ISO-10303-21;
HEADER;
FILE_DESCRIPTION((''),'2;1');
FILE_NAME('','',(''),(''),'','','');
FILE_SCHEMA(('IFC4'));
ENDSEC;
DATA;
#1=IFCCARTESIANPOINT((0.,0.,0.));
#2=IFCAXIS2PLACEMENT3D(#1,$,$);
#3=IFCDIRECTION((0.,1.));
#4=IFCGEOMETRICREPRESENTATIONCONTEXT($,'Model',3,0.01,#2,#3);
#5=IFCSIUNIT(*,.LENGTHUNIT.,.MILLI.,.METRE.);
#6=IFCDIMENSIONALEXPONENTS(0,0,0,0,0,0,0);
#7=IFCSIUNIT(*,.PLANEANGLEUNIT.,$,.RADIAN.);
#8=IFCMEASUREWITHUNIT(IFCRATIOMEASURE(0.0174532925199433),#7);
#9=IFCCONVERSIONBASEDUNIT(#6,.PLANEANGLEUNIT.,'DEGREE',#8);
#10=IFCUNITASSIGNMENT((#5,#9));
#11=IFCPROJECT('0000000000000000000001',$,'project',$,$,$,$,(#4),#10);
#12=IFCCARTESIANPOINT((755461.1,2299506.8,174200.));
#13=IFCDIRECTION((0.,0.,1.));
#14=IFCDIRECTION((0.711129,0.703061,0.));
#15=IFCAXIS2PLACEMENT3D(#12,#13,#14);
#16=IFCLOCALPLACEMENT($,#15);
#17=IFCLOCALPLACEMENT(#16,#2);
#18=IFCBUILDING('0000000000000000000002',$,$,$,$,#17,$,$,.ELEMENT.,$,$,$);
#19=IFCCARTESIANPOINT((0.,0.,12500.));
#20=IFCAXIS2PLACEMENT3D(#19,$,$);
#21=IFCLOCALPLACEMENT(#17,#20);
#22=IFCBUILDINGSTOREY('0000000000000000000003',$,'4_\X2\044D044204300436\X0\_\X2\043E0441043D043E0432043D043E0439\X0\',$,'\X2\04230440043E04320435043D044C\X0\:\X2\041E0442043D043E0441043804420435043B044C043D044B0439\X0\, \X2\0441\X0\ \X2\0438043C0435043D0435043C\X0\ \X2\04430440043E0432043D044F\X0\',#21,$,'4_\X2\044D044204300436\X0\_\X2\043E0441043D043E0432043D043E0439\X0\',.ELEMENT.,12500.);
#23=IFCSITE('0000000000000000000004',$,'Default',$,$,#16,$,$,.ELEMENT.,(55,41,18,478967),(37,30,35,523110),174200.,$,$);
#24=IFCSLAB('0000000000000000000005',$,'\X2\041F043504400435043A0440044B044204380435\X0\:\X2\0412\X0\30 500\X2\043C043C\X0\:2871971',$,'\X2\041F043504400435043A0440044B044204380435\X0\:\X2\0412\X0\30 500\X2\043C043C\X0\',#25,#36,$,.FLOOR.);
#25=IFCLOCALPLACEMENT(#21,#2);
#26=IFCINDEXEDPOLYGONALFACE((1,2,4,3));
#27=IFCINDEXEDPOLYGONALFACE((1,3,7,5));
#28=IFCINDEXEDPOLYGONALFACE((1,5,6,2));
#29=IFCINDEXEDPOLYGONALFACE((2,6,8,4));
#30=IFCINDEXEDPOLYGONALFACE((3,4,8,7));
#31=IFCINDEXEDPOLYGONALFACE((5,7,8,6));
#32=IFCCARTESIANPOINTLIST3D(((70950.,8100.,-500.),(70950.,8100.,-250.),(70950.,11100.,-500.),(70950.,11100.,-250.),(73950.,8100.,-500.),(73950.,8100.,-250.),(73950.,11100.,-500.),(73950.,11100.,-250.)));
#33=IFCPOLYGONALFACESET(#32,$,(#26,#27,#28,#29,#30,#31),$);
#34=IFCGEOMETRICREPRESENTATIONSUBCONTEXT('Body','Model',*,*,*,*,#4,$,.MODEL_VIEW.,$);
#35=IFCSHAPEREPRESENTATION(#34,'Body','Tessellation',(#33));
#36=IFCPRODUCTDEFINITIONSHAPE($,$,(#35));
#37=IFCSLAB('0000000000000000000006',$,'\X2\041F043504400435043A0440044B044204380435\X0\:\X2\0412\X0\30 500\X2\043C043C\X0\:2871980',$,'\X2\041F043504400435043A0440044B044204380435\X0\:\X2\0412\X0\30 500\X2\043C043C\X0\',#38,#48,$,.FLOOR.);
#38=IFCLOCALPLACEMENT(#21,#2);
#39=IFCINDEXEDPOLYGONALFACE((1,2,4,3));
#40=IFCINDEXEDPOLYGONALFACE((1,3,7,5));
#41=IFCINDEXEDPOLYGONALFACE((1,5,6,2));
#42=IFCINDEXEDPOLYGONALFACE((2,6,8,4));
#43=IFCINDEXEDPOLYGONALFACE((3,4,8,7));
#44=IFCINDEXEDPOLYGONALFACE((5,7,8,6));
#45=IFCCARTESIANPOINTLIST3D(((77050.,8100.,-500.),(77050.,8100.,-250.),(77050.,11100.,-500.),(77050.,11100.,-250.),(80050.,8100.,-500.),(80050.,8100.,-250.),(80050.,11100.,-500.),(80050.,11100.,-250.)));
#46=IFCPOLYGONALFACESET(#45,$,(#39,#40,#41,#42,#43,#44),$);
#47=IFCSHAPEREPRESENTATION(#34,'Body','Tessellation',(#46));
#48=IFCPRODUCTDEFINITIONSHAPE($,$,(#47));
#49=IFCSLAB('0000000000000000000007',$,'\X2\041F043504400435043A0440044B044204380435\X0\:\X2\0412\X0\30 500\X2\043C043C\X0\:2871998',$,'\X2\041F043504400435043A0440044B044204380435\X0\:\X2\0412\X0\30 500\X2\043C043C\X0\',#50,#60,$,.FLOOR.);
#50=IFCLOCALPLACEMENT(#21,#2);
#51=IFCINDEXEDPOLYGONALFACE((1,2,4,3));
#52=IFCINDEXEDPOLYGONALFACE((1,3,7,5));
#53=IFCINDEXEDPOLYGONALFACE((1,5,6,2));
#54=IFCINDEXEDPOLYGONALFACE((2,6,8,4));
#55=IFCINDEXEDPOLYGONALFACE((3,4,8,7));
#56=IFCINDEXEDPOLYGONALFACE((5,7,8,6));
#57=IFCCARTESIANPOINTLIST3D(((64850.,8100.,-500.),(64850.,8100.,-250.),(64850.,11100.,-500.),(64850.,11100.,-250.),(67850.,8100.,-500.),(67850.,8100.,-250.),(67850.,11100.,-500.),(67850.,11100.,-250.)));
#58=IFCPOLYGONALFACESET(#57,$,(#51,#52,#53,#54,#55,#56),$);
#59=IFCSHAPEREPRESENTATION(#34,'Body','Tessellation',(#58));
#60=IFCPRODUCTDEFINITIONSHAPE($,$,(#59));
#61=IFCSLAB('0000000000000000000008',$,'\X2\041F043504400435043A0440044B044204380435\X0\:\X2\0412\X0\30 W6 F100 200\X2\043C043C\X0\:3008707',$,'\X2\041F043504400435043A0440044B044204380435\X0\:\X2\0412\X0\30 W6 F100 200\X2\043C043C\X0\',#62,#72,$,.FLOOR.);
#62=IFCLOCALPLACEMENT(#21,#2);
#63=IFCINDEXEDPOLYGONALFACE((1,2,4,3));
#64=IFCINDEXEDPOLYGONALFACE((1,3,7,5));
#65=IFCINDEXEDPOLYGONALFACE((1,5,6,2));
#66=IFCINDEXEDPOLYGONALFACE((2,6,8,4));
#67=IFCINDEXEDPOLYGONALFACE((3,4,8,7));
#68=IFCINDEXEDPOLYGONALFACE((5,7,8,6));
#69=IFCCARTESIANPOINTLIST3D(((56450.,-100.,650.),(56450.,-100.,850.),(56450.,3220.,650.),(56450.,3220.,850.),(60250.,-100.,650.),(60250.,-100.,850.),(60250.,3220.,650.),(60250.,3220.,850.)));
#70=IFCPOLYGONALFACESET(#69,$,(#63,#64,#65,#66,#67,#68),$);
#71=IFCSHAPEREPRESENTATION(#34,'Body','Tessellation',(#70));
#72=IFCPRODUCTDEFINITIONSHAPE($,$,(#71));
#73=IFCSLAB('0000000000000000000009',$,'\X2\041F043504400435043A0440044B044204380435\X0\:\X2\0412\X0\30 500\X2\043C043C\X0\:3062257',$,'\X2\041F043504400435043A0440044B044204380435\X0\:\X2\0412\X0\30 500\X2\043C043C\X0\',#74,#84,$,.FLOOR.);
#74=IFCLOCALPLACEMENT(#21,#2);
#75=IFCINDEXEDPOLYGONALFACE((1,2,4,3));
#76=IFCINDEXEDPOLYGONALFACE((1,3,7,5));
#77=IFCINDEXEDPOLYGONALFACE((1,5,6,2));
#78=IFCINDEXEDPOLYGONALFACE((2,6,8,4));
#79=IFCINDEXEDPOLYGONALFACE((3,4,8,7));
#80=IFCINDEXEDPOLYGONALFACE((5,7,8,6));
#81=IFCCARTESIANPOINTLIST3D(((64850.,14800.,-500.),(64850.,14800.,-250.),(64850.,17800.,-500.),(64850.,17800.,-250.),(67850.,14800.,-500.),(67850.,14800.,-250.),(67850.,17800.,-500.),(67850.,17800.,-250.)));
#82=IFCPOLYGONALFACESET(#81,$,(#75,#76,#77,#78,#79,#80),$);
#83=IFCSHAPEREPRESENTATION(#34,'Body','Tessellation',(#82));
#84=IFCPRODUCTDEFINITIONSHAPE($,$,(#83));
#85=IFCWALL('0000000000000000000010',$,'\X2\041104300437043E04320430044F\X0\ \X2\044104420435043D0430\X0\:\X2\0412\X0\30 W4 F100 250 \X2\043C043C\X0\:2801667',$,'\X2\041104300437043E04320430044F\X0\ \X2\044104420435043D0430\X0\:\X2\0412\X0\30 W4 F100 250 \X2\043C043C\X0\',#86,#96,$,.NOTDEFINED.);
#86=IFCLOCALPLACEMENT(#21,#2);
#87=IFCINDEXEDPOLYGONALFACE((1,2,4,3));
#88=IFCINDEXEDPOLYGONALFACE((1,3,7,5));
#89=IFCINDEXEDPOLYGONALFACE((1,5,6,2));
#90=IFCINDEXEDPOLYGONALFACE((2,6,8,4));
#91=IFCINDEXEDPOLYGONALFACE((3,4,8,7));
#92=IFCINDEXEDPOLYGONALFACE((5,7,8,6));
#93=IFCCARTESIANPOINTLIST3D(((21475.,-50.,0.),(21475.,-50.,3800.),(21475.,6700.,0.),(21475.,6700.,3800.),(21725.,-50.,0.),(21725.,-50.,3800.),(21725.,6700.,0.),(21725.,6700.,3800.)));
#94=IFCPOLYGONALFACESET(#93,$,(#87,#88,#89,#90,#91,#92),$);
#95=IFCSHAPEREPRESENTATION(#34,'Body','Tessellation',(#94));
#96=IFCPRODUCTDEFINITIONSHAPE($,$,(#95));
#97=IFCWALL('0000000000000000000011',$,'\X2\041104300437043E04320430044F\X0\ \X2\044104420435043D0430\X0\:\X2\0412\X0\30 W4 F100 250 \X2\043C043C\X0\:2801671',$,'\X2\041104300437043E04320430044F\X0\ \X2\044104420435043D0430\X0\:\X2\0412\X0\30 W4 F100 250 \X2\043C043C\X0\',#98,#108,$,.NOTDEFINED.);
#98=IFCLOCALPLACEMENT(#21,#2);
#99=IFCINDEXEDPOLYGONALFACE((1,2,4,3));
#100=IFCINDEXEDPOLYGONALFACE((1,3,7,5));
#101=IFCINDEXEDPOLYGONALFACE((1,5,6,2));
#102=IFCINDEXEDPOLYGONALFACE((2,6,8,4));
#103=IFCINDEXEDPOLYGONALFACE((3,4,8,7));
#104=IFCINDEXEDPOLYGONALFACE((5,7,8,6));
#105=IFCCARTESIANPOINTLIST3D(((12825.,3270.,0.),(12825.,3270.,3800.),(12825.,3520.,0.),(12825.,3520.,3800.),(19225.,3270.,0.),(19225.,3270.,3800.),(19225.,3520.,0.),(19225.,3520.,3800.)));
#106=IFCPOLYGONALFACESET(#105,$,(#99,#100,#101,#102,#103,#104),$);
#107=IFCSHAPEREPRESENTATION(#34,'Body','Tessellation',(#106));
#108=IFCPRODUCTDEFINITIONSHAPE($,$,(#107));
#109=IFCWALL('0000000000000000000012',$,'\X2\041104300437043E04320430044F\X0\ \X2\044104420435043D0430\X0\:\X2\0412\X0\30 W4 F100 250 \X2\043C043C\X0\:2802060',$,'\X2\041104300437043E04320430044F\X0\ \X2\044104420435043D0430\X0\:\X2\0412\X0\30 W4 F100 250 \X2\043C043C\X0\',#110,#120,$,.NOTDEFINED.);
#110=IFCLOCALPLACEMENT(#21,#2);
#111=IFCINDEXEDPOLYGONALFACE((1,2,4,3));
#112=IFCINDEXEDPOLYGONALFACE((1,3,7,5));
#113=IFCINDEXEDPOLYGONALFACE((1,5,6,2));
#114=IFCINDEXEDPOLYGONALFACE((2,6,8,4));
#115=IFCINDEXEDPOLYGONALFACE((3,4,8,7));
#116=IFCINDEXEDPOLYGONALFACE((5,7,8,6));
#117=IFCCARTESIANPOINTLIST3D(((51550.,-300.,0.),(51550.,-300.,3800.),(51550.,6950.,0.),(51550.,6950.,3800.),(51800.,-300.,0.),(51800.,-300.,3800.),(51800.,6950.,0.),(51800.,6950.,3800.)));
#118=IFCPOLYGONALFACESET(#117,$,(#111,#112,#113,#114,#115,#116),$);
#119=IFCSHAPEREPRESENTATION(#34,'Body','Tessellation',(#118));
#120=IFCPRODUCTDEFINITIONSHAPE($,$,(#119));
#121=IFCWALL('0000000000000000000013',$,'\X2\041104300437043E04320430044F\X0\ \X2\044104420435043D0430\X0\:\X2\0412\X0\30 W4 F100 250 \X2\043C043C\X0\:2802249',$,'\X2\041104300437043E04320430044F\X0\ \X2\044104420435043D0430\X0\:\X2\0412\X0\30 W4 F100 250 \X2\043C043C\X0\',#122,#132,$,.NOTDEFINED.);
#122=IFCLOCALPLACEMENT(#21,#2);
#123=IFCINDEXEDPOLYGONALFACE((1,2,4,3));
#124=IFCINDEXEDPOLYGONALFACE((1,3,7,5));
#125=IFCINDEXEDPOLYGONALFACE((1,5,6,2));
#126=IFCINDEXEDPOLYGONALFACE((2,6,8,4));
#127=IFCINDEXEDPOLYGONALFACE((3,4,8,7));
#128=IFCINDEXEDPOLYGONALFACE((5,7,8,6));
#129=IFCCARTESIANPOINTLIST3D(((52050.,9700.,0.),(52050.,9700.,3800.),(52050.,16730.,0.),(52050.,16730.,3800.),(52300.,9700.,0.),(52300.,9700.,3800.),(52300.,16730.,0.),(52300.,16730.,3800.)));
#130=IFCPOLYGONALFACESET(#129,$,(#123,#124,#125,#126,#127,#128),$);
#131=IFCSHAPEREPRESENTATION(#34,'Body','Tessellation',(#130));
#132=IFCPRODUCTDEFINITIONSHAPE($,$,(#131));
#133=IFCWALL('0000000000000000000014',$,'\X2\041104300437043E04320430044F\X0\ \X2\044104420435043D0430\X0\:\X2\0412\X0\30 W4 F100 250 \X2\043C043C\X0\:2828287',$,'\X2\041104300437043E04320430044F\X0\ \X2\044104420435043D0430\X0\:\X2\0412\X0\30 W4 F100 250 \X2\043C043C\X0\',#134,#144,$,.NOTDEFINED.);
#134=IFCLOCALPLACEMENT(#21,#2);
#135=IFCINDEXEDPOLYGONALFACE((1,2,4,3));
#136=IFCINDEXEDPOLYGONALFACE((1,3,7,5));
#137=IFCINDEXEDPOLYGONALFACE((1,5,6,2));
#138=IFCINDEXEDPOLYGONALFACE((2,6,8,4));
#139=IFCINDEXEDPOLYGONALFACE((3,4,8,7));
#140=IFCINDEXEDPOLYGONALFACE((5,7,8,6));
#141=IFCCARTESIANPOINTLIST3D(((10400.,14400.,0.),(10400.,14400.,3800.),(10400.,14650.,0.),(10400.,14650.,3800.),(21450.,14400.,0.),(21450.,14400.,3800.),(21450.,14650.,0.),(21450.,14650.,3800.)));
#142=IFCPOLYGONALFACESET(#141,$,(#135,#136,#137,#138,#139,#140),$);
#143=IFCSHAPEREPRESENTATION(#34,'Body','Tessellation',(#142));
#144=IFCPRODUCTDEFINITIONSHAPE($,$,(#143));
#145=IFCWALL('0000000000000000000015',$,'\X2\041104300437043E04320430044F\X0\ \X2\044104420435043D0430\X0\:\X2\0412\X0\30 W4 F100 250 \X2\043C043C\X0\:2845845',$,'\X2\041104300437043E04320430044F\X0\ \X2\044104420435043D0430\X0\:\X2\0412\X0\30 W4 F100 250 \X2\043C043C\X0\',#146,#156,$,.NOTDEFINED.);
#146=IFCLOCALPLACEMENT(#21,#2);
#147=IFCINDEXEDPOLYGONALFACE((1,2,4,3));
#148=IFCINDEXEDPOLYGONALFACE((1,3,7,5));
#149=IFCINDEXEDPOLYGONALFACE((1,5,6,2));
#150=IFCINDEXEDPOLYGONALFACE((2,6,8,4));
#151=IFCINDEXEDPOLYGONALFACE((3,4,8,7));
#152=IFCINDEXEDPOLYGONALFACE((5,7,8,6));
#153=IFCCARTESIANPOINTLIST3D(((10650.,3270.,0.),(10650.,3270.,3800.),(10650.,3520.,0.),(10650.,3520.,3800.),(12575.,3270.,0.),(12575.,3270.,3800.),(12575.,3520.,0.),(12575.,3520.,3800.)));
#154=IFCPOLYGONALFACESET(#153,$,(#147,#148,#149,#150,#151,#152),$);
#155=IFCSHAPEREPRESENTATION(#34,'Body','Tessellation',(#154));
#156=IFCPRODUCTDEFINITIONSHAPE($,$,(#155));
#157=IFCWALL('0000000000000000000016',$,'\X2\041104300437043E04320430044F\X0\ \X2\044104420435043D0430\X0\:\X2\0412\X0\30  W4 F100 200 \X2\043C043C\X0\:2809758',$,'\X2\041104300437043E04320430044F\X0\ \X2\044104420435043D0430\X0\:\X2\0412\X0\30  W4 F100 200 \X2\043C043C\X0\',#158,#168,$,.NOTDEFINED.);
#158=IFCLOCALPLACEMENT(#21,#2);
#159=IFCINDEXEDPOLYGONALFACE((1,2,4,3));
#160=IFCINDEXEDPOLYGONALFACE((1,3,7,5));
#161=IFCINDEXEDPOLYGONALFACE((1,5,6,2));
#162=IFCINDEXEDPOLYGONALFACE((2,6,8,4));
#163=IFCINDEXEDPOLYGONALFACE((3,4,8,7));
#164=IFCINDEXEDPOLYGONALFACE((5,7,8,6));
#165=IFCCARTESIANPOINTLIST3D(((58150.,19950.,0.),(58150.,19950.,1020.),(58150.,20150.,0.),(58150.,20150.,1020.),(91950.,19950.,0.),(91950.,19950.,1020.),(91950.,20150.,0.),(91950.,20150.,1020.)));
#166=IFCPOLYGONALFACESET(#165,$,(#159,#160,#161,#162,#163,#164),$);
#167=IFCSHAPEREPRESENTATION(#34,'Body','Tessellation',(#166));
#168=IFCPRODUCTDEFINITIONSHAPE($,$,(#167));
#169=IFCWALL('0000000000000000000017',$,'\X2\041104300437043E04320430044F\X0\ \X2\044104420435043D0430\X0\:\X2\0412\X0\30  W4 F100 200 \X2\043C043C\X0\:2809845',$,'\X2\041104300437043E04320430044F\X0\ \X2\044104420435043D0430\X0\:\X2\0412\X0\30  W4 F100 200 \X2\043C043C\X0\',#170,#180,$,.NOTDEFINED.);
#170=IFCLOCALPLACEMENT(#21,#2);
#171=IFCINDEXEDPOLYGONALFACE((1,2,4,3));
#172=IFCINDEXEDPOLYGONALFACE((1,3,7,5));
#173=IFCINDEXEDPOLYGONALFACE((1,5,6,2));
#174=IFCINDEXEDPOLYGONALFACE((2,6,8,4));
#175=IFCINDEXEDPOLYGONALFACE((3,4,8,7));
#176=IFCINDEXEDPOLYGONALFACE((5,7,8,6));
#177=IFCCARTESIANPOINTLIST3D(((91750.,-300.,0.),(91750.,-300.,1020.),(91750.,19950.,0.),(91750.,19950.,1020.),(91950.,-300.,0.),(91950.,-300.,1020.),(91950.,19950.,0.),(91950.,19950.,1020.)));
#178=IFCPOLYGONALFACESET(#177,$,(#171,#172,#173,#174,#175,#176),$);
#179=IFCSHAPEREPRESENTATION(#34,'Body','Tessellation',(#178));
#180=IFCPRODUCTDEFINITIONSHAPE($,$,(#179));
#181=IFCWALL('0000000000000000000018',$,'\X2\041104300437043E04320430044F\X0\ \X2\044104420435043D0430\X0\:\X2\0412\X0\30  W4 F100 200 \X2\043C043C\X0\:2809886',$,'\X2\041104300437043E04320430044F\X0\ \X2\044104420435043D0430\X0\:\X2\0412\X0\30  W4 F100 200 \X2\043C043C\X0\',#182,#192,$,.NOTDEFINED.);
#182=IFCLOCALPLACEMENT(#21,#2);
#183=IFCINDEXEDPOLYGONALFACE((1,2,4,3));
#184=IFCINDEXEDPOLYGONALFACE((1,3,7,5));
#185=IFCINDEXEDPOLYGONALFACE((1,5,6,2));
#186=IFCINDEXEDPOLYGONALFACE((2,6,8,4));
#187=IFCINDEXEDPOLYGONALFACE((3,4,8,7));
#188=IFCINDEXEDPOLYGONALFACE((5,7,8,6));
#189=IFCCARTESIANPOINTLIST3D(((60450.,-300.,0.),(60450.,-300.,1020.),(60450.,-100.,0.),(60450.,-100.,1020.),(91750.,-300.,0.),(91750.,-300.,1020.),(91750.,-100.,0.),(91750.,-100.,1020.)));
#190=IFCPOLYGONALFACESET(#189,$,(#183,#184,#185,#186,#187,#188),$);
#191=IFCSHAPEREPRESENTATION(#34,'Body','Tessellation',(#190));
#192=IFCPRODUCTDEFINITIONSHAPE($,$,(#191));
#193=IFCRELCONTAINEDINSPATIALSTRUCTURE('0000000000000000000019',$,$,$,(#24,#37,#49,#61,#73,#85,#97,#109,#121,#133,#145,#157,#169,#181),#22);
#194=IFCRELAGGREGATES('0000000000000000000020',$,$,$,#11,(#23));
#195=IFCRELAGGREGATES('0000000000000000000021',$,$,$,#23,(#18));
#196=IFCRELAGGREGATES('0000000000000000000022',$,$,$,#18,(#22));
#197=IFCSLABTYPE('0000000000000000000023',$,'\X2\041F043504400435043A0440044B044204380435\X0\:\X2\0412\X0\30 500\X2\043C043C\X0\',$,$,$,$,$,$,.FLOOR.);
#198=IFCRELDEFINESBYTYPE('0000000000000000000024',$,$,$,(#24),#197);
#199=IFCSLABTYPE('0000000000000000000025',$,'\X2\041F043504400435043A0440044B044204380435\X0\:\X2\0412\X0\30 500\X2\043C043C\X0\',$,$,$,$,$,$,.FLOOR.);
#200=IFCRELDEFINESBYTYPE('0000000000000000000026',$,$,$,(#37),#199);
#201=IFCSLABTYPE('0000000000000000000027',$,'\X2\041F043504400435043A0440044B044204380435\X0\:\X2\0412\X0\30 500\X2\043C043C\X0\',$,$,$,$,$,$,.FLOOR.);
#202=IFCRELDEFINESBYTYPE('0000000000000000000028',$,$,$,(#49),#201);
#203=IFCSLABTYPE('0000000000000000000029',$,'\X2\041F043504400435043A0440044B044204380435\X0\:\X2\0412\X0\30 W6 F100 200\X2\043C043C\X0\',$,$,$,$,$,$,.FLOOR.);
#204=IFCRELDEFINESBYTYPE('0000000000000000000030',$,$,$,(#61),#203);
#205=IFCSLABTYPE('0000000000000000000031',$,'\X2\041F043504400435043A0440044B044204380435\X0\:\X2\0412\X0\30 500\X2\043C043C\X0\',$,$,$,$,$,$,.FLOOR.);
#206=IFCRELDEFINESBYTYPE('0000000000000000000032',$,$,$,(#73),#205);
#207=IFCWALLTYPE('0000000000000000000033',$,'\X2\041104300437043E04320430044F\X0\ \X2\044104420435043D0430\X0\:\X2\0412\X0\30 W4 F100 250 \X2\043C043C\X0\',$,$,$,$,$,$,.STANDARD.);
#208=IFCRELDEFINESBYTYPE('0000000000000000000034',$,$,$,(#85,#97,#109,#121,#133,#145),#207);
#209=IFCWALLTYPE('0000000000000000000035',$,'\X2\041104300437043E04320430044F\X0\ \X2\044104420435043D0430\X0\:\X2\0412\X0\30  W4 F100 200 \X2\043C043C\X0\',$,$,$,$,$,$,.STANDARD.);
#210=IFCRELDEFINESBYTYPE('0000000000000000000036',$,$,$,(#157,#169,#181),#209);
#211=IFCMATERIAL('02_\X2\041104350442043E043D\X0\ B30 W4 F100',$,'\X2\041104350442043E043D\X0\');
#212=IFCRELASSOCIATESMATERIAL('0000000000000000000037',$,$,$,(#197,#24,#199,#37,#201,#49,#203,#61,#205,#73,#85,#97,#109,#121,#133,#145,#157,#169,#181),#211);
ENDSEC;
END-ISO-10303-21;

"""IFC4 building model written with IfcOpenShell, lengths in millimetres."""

from ifc_helpers import new_model, entity, si_unit, converted_unit, direction, frame, origin, place, context, subcontext, project, spatial, indexed_curve, outline, extrude, material, type_object, element, save


model = new_model("IFC4")

# Units and contexts
model_context = context("Model", 3, precision=0.01, world=origin(), true_north=direction((0.0, 1.0)))
body_context = subcontext(model_context, "Body", "Model", "MODEL_VIEW")
ifc_project = project(units=[si_unit("LENGTHUNIT", "METRE", prefix="MILLI"), converted_unit("PLANEANGLEUNIT", "DEGREE", entity("IfcRatioMeasure", 0.0174532925199433), si_unit("PLANEANGLEUNIT", "RADIAN"), dimensions=[0, 0, 0, 0, 0, 0, 0])], contexts=[model_context])

# Site, building, storey
site_placement = place(None, frame((755461.1, 2299506.8, 174200.0), z_axis=(0.0, 0.0, 1.0), x_axis=(0.711129, 0.703061, 0.0)))
site = spatial("IfcSite", under=ifc_project, at=site_placement, Name="Default", CompositionType="ELEMENT", RefLatitude=(55, 41, 18, 478967), RefLongitude=(37, 30, 35, 523110), RefElevation=174200.0)
building_placement = place(site_placement, origin())
building = spatial("IfcBuilding", under=site, at=building_placement, CompositionType="ELEMENT")
storey_placement = place(building_placement, frame((0.0, 0.0, 12500.0)))
storey = spatial("IfcBuildingStorey", under=building, at=storey_placement, Name="4_этаж_основной", ObjectType="Уровень:Относительный, с именем уровня", LongName="4_этаж_основной", CompositionType="ELEMENT", Elevation=12500.0)

# Slabs
ifc_material_1 = material(Name="02_Бетон B30 W4 F100", Category="Бетон")
slab_type_1 = type_object("IfcSlabType", Name="Перекрытие:В30 500мм", PredefinedType="FLOOR", material=ifc_material_1)
slab_1_placement = place(storey_placement, origin())
element("IfcSlab", 1, at=slab_1_placement, inside=storey, type_object=slab_type_1, material=ifc_material_1, Name="Перекрытие:В30 500мм:2871971", ObjectType="Перекрытие:В30 500мм", PredefinedType="FLOOR", context=body_context, shape_type="SweptSolid", body=[
    extrude(outline(indexed_curve([(-1500.0, -1500.0), (1500.0, -1500.0), (1500.0, 1500.0), (-1500.0, 1500.0), (-1500.0, -1500.0)], self_intersect=False)), frame((72450.0, 9600.0, -500.0), z_axis=(0.0, 0.0, 1.0), x_axis=(0.0, -1.0, 0.0)), (0.0, 0.0, 1.0), 250.0),
])
slab_type_2 = type_object("IfcSlabType", Name="Перекрытие:В30 500мм", PredefinedType="FLOOR", material=ifc_material_1)
slab_2_placement = place(storey_placement, origin())
element("IfcSlab", 2, at=slab_2_placement, inside=storey, type_object=slab_type_2, material=ifc_material_1, Name="Перекрытие:В30 500мм:2871980", ObjectType="Перекрытие:В30 500мм", PredefinedType="FLOOR", context=body_context, shape_type="SweptSolid", body=[
    extrude(outline(indexed_curve([(-1500.0, -1500.0), (1500.0, -1500.0), (1500.0, 1500.0), (-1500.0, 1500.0), (-1500.0, -1500.0)], self_intersect=False)), frame((78550.0, 9600.0, -500.0), z_axis=(0.0, 0.0, 1.0), x_axis=(0.0, -1.0, 0.0)), (0.0, 0.0, 1.0), 250.0),
])
slab_type_3 = type_object("IfcSlabType", Name="Перекрытие:В30 500мм", PredefinedType="FLOOR", material=ifc_material_1)
slab_3_placement = place(storey_placement, origin())
element("IfcSlab", 3, at=slab_3_placement, inside=storey, type_object=slab_type_3, material=ifc_material_1, Name="Перекрытие:В30 500мм:2871998", ObjectType="Перекрытие:В30 500мм", PredefinedType="FLOOR", context=body_context, shape_type="SweptSolid", body=[
    extrude(outline(indexed_curve([(-1500.0, -1500.0), (1500.0, -1500.0), (1500.0, 1500.0), (-1500.0, 1500.0), (-1500.0, -1500.0)], self_intersect=False)), frame((66350.0, 9600.0, -500.0), z_axis=(0.0, 0.0, 1.0), x_axis=(0.0, -1.0, 0.0)), (0.0, 0.0, 1.0), 250.0),
])
slab_type_4 = type_object("IfcSlabType", Name="Перекрытие:В30 W6 F100 200мм", PredefinedType="FLOOR", material=ifc_material_1)
slab_4_placement = place(storey_placement, origin())
element("IfcSlab", 4, at=slab_4_placement, inside=storey, type_object=slab_type_4, material=ifc_material_1, Name="Перекрытие:В30 W6 F100 200мм:3008707", ObjectType="Перекрытие:В30 W6 F100 200мм", PredefinedType="FLOOR", context=body_context, shape_type="SweptSolid", body=[
    extrude(outline(indexed_curve([(-1660.0, -1900.0), (1660.0, -1900.0), (1660.0, 1900.0), (-1660.0, 1900.0), (-1660.0, -1900.0)], self_intersect=False)), frame((58350.0, 1560.0, 850.0), z_axis=(0.0, 0.0, -1.0), x_axis=(0.0, 1.0, 0.0)), (0.0, 0.0, 1.0), 200.0),
])
slab_type_5 = type_object("IfcSlabType", Name="Перекрытие:В30 500мм", PredefinedType="FLOOR", material=ifc_material_1)
slab_5_placement = place(storey_placement, origin())
element("IfcSlab", 5, at=slab_5_placement, inside=storey, type_object=slab_type_5, material=ifc_material_1, Name="Перекрытие:В30 500мм:3062257", ObjectType="Перекрытие:В30 500мм", PredefinedType="FLOOR", context=body_context, shape_type="SweptSolid", body=[
    extrude(outline(indexed_curve([(-1500.0, -1500.0), (1500.0, -1500.0), (1500.0, 1500.0), (-1500.0, 1500.0), (-1500.0, -1500.0)], self_intersect=False)), frame((66350.0, 16300.0, -500.0), z_axis=(0.0, 0.0, 1.0), x_axis=(0.0, -1.0, 0.0)), (0.0, 0.0, 1.0), 250.0),
])

# Walls
wall_type_1 = type_object("IfcWallType", Name="Базовая стена:В30 W4 F100 250 мм", PredefinedType="STANDARD")
wall_1_placement = place(storey_placement, frame((21600.0, -50.0, 0.0), z_axis=(0.0, 0.0, 1.0), x_axis=(0.0, 1.0, 0.0)))
element("IfcWall", 6, at=wall_1_placement, inside=storey, type_object=wall_type_1, material=ifc_material_1, Name="Базовая стена:В30 W4 F100 250 мм:2801667", ObjectType="Базовая стена:В30 W4 F100 250 мм", PredefinedType="NOTDEFINED", context=body_context, shape_type="SweptSolid", body=[
    extrude(outline(indexed_curve([(6750.0, 125.0), (0.0, 125.0), (0.0, -125.0), (6750.0, -125.0), (6750.0, 125.0)], self_intersect=False)), origin(), (0.0, 0.0, 1.0), 3800.0),
])
wall_2_placement = place(storey_placement, frame((12825.0, 3395.0, 0.0)))
element("IfcWall", 7, at=wall_2_placement, inside=storey, type_object=wall_type_1, material=ifc_material_1, Name="Базовая стена:В30 W4 F100 250 мм:2801671", ObjectType="Базовая стена:В30 W4 F100 250 мм", PredefinedType="NOTDEFINED", context=body_context, shape_type="SweptSolid", body=[
    extrude(outline(indexed_curve([(6400.0, 125.0), (0.0, 125.0), (0.0, -125.0), (6400.0, -125.0), (6400.0, 125.0)], self_intersect=False)), origin(), (0.0, 0.0, 1.0), 3800.0),
])
wall_3_placement = place(storey_placement, frame((51675.0, 6950.0, 0.0), z_axis=(0.0, 0.0, 1.0), x_axis=(0.0, -1.0, 0.0)))
element("IfcWall", 8, at=wall_3_placement, inside=storey, type_object=wall_type_1, material=ifc_material_1, Name="Базовая стена:В30 W4 F100 250 мм:2802060", ObjectType="Базовая стена:В30 W4 F100 250 мм", PredefinedType="NOTDEFINED", context=body_context, shape_type="SweptSolid", body=[
    extrude(outline(indexed_curve([(7250.0, 125.0), (0.0, 125.0), (0.0, -125.0), (7250.0, -125.0), (7250.0, 125.0)], self_intersect=False)), origin(), (0.0, 0.0, 1.0), 3800.0),
])
wall_4_placement = place(storey_placement, frame((52175.0, 16730.0, 0.0), z_axis=(0.0, 0.0, 1.0), x_axis=(0.0, -1.0, 0.0)))
element("IfcWall", 9, at=wall_4_placement, inside=storey, type_object=wall_type_1, material=ifc_material_1, Name="Базовая стена:В30 W4 F100 250 мм:2802249", ObjectType="Базовая стена:В30 W4 F100 250 мм", PredefinedType="NOTDEFINED", context=body_context, shape_type="SweptSolid", body=[
    extrude(outline(indexed_curve([(7030.0, 125.0), (0.0, 125.0), (0.0, -125.0), (7030.0, -125.0), (7030.0, 125.0)], self_intersect=False)), origin(), (0.0, 0.0, 1.0), 3800.0),
])
wall_5_placement = place(storey_placement, frame((21450.0, 14525.0, 0.0), z_axis=(0.0, 0.0, 1.0), x_axis=(-1.0, 0.0, 0.0)))
element("IfcWall", 10, at=wall_5_placement, inside=storey, type_object=wall_type_1, material=ifc_material_1, Name="Базовая стена:В30 W4 F100 250 мм:2828287", ObjectType="Базовая стена:В30 W4 F100 250 мм", PredefinedType="NOTDEFINED", context=body_context, shape_type="SweptSolid", body=[
    extrude(outline(indexed_curve([(11050.0, 125.0), (0.0, 125.0), (0.0, -125.0), (11050.0, -125.0), (11050.0, 125.0)], self_intersect=False)), origin(), (0.0, 0.0, 1.0), 3800.0),
])
wall_6_placement = place(storey_placement, frame((12575.0, 3395.0, 0.0), z_axis=(0.0, 0.0, 1.0), x_axis=(-1.0, 0.0, 0.0)))
element("IfcWall", 11, at=wall_6_placement, inside=storey, type_object=wall_type_1, material=ifc_material_1, Name="Базовая стена:В30 W4 F100 250 мм:2845845", ObjectType="Базовая стена:В30 W4 F100 250 мм", PredefinedType="NOTDEFINED", context=body_context, shape_type="SweptSolid", body=[
    extrude(outline(indexed_curve([(1925.0, 125.0), (0.0, 125.0), (0.0, -125.0), (1925.0, -125.0), (1925.0, 125.0)], self_intersect=False)), origin(), (0.0, 0.0, 1.0), 3800.0),
])
wall_type_2 = type_object("IfcWallType", Name="Базовая стена:В30  W4 F100 200 мм", PredefinedType="STANDARD")
wall_7_placement = place(storey_placement, frame((58150.0, 20050.0, 0.0)))
element("IfcWall", 12, at=wall_7_placement, inside=storey, type_object=wall_type_2, material=ifc_material_1, Name="Базовая стена:В30  W4 F100 200 мм:2809758", ObjectType="Базовая стена:В30  W4 F100 200 мм", PredefinedType="NOTDEFINED", context=body_context, shape_type="SweptSolid", body=[
    extrude(outline(indexed_curve([(33800.0, 100.0), (0.0, 100.0), (0.0, -100.0), (33800.0, -100.0), (33800.0, 100.0)], self_intersect=False)), origin(), (0.0, 0.0, 1.0), 1020.0),
])
wall_8_placement = place(storey_placement, frame((91850.0, 19950.0, 0.0), z_axis=(0.0, 0.0, 1.0), x_axis=(0.0, -1.0, 0.0)))
element("IfcWall", 13, at=wall_8_placement, inside=storey, type_object=wall_type_2, material=ifc_material_1, Name="Базовая стена:В30  W4 F100 200 мм:2809845", ObjectType="Базовая стена:В30  W4 F100 200 мм", PredefinedType="NOTDEFINED", context=body_context, shape_type="SweptSolid", body=[
    extrude(outline(indexed_curve([(20250.0, 100.0), (0.0, 100.0), (0.0, -100.0), (20250.0, -100.0), (20250.0, 100.0)], self_intersect=False)), origin(), (0.0, 0.0, 1.0), 1020.0),
])
wall_9_placement = place(storey_placement, frame((91750.0, -200.0, 0.0), z_axis=(0.0, 0.0, 1.0), x_axis=(-1.0, 0.0, 0.0)))
element("IfcWall", 14, at=wall_9_placement, inside=storey, type_object=wall_type_2, material=ifc_material_1, Name="Базовая стена:В30  W4 F100 200 мм:2809886", ObjectType="Базовая стена:В30  W4 F100 200 мм", PredefinedType="NOTDEFINED", context=body_context, shape_type="SweptSolid", body=[
    extrude(outline(indexed_curve([(31300.0, 100.0), (0.0, 100.0), (0.0, -100.0), (31300.0, -100.0), (31300.0, 100.0)], self_intersect=False)), origin(), (0.0, 0.0, 1.0), 1020.0),
])

save(model, "model.ifc")
